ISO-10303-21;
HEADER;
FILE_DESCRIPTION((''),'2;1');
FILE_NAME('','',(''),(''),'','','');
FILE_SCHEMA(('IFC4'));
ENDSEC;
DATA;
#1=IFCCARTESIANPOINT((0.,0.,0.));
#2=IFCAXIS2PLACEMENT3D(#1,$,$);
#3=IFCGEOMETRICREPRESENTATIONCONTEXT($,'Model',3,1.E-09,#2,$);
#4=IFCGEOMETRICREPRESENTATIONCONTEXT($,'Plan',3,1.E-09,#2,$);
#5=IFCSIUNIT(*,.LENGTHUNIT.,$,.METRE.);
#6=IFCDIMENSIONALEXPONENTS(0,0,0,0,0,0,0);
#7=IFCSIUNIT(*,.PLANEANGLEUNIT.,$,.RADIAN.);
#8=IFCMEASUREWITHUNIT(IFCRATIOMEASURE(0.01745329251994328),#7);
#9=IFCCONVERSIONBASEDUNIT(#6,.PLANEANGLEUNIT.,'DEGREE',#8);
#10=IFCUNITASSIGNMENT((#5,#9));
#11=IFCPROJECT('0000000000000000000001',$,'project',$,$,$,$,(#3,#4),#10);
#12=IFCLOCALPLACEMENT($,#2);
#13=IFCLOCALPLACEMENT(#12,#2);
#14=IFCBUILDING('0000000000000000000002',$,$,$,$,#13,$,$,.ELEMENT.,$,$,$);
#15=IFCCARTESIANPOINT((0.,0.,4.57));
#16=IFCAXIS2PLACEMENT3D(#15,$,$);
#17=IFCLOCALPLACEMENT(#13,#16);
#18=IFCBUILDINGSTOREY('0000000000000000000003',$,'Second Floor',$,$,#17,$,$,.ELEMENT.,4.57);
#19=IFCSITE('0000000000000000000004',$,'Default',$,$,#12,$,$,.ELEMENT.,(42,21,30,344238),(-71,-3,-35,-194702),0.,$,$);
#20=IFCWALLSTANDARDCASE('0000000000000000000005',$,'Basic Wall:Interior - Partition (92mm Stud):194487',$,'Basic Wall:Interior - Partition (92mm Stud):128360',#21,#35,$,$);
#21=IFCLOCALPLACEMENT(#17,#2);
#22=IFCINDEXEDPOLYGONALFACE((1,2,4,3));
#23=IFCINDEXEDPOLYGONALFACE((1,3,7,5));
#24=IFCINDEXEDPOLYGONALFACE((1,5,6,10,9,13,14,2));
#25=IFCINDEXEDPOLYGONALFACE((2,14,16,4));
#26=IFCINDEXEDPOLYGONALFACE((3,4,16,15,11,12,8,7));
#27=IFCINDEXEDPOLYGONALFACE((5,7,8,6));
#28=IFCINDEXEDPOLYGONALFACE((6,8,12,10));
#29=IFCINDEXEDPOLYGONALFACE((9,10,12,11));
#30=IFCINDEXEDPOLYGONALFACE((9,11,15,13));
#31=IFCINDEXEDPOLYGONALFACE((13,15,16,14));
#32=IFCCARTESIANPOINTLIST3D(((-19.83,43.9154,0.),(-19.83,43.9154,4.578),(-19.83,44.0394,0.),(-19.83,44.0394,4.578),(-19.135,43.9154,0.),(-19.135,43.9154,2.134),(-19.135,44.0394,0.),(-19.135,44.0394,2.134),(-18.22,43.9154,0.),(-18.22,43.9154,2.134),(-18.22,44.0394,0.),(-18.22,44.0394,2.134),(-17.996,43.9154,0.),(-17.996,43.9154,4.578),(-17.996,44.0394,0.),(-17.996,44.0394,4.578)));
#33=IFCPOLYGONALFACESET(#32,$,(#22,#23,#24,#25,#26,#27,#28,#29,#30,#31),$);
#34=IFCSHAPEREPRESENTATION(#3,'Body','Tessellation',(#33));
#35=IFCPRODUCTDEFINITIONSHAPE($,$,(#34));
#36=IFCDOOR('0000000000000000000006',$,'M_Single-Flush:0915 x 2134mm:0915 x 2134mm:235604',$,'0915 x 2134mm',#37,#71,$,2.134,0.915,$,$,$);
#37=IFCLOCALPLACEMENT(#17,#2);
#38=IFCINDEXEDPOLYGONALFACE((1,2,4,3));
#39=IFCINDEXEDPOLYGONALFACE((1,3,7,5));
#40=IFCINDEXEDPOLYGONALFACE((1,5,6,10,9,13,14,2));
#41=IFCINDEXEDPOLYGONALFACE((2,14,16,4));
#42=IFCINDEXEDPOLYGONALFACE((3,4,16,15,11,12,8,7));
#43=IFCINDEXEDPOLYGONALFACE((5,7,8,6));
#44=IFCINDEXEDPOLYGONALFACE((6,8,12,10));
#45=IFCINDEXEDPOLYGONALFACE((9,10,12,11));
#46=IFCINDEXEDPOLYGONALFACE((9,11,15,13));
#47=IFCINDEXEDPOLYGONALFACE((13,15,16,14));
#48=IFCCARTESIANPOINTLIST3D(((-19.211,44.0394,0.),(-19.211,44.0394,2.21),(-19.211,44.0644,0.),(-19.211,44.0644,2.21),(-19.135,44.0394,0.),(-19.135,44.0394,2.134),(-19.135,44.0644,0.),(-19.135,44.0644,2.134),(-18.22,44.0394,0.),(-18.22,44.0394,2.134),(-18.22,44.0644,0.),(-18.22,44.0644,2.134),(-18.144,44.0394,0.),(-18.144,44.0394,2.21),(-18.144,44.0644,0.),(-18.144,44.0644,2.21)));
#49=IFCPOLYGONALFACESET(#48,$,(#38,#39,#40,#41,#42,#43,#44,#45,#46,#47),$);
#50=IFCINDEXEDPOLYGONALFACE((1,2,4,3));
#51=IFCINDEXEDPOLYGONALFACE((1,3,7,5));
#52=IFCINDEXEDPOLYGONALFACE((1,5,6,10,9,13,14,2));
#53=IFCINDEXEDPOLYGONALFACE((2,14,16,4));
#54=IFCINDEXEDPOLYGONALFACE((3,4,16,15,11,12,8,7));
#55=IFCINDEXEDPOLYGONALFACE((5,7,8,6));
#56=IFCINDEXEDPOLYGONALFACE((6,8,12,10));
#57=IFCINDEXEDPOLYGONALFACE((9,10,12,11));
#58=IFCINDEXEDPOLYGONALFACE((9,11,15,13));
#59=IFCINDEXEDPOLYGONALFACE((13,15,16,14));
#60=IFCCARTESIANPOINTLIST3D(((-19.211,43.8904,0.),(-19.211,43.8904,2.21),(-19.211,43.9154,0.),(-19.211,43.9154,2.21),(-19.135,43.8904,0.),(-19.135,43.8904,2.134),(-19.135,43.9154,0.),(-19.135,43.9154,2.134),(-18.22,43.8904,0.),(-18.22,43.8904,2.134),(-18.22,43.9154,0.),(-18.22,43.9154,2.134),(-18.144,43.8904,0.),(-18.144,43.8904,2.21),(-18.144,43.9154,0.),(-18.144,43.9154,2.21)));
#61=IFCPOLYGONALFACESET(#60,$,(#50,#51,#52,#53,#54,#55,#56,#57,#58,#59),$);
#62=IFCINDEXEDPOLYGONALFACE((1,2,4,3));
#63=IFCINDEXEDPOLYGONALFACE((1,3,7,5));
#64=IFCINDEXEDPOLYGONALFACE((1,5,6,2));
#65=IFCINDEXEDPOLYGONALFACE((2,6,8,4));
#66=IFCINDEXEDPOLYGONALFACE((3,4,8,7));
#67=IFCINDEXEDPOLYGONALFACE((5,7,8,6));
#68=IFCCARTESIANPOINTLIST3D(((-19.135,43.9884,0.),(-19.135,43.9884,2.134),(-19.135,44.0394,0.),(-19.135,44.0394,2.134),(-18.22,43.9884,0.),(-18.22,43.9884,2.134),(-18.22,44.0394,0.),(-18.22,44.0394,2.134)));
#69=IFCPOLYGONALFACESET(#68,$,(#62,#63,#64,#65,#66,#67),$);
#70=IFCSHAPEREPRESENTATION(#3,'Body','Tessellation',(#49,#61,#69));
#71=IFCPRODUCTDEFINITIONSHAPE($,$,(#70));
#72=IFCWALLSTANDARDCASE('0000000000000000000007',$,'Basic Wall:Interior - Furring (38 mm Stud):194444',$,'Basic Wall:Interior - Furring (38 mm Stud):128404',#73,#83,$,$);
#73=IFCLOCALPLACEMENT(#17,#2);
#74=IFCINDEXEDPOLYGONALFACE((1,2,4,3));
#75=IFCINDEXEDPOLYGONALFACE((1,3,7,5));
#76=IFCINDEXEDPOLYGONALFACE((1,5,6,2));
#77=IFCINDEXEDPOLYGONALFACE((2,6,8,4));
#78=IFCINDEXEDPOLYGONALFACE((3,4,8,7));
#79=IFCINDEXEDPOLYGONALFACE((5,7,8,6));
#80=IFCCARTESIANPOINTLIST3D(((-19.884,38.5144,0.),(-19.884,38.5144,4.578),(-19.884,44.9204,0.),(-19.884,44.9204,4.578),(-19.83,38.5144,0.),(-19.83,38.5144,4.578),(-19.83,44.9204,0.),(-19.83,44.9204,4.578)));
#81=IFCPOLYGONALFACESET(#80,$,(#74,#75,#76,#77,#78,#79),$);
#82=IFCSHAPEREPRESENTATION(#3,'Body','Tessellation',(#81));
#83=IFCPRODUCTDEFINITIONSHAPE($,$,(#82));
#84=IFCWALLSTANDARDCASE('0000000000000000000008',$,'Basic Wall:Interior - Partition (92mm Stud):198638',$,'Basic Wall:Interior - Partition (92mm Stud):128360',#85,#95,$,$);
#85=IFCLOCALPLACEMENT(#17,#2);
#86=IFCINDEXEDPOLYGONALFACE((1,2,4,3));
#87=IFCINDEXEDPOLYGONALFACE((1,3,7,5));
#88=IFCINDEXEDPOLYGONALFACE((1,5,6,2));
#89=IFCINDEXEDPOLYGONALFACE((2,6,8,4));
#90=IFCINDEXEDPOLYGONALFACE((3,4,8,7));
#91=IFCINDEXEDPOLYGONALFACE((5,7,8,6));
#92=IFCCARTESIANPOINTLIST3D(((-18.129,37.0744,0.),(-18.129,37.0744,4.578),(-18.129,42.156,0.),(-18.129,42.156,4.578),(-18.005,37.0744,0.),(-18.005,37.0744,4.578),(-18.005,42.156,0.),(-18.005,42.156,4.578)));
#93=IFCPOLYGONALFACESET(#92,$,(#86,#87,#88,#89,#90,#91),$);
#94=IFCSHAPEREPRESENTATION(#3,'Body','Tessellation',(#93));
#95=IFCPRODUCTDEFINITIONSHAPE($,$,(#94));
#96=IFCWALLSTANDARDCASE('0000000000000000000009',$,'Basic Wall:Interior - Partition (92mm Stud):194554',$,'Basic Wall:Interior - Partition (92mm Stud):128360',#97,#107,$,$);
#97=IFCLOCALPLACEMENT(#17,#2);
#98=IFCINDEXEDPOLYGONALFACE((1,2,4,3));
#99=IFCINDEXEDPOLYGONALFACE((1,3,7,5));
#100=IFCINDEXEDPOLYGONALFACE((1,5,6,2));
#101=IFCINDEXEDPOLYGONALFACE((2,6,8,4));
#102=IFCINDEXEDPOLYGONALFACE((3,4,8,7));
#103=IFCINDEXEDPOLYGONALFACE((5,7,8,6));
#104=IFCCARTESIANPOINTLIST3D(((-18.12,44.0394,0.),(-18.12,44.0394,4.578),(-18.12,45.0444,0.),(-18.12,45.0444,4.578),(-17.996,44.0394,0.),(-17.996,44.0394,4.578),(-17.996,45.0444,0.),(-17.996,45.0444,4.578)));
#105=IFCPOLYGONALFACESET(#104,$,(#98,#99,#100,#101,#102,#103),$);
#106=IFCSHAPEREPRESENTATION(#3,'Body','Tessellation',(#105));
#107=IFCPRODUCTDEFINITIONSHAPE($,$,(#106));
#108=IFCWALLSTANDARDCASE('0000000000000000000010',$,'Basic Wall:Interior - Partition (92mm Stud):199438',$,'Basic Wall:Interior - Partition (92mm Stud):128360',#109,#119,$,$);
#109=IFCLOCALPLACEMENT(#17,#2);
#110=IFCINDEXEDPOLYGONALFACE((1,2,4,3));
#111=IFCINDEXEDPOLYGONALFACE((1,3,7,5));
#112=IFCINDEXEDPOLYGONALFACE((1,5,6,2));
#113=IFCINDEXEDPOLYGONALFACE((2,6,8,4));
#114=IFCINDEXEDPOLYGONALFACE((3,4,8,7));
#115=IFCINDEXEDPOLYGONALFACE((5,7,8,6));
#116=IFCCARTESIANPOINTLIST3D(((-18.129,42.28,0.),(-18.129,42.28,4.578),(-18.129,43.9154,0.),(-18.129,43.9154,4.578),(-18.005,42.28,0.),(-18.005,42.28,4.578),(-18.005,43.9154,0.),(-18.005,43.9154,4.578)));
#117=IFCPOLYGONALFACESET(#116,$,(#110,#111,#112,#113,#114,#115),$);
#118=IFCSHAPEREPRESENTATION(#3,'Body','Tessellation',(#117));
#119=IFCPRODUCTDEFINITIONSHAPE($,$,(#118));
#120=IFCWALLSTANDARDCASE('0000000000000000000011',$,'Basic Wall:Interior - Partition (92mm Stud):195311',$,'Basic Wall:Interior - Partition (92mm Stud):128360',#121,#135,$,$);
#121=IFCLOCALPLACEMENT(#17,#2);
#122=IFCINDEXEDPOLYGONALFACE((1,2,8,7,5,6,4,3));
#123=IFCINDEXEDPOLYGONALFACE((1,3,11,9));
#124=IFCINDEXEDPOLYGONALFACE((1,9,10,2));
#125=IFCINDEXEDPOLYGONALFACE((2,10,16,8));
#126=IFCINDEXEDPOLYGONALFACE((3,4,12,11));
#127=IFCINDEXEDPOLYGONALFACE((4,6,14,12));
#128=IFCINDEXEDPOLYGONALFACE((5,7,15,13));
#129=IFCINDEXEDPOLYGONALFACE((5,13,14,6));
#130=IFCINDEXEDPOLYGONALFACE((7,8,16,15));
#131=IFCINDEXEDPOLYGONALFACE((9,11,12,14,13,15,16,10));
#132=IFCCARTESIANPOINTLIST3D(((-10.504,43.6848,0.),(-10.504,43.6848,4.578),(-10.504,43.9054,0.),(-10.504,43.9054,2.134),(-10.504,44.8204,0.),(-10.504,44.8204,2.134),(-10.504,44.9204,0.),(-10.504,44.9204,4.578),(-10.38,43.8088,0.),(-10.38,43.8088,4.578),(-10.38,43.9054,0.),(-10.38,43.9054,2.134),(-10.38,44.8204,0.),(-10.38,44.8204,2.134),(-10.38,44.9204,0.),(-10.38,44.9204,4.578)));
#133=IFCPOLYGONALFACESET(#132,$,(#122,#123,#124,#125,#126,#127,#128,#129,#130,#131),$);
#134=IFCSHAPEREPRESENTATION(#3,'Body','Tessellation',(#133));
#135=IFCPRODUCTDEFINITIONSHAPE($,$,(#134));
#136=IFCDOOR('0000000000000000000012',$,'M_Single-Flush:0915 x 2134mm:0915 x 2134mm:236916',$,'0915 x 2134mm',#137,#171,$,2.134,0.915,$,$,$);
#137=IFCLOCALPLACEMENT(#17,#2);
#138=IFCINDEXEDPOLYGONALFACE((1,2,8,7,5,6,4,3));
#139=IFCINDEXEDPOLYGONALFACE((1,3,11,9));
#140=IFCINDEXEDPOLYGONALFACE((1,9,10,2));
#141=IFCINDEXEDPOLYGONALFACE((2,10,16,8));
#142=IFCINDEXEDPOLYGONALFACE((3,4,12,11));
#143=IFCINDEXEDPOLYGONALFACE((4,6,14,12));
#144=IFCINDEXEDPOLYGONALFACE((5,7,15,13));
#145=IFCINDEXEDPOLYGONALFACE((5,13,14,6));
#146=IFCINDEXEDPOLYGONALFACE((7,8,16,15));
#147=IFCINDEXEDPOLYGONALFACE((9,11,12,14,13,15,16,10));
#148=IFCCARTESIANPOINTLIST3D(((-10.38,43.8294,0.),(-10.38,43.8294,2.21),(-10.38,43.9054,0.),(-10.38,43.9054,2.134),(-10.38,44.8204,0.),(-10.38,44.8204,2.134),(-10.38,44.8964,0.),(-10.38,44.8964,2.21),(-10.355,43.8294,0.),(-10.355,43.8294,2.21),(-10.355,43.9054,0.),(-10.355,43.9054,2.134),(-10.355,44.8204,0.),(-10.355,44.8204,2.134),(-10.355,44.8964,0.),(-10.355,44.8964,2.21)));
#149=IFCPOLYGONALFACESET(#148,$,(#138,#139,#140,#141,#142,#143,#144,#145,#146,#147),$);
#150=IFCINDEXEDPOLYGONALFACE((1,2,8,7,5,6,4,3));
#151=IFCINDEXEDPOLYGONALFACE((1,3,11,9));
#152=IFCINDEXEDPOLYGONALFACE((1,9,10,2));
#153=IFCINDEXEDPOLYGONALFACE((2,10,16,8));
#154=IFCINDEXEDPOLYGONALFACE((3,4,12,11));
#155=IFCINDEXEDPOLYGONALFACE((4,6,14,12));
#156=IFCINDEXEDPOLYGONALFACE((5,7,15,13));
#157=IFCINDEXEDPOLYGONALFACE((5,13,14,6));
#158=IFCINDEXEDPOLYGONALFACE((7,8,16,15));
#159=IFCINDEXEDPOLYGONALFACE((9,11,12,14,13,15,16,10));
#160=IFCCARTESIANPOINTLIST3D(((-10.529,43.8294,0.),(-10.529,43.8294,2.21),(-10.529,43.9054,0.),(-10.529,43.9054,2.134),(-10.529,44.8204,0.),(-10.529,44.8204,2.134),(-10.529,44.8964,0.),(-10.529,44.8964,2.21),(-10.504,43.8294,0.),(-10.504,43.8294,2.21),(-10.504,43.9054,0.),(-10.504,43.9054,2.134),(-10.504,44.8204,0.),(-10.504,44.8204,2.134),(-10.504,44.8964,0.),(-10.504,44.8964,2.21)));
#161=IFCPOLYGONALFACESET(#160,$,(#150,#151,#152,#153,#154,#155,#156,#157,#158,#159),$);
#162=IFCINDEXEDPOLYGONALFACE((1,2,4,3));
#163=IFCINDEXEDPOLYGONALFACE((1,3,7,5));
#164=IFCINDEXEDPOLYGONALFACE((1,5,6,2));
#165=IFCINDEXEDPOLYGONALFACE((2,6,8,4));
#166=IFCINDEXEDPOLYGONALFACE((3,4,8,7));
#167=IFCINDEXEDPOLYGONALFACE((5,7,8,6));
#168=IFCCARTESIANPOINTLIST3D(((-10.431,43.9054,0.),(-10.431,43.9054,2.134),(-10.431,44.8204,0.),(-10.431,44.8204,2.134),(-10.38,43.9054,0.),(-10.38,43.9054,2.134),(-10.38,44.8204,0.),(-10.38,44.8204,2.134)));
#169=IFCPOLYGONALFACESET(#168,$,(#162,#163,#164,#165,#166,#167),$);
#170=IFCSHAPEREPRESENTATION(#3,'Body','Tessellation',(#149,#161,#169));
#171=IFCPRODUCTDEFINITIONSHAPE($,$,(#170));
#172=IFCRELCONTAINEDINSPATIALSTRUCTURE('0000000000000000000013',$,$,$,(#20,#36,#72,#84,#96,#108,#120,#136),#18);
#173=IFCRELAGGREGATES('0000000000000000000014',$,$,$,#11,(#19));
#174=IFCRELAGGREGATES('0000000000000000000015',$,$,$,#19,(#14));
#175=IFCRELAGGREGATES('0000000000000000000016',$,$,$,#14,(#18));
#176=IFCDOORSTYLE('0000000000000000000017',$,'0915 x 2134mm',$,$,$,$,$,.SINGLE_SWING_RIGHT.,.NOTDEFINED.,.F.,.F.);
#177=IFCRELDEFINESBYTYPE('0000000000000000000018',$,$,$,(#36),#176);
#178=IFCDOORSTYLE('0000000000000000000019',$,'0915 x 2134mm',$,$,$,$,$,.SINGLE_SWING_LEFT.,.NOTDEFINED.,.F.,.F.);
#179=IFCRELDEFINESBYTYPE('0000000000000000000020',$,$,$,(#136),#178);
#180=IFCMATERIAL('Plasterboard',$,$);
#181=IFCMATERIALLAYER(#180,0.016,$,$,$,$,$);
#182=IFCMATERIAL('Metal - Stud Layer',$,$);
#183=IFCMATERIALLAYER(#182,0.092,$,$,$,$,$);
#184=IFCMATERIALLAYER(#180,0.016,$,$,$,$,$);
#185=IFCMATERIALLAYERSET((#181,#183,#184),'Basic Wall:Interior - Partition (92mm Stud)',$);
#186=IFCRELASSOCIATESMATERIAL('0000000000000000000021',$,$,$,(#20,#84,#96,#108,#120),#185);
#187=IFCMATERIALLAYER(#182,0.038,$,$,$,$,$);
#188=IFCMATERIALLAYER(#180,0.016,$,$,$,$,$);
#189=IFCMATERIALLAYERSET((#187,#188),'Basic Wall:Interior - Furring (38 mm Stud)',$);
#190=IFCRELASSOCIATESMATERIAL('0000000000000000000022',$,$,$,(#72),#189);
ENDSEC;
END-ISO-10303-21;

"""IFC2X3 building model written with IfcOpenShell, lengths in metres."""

from ifc_helpers import new_model, entity, si_unit, converted_unit, frame, frame_2d, origin, origin_2d_with_axis, place, context, project, spatial, polyline, rectangle, outline, extrude, source, transform, mapped, material, layer, layer_set, layer_usage, type_object, type_shapes, element, fill, save


model = new_model("IFC2X3")

# Units and contexts
model_context = context("Model", 3, precision=1e-09, world=origin())
plan_context = context("Plan", 3, precision=1e-09, world=origin())
ifc_project = project(units=[si_unit("LENGTHUNIT", "METRE"), converted_unit("PLANEANGLEUNIT", "DEGREE", entity("IfcRatioMeasure", 0.01745329251994328), si_unit("PLANEANGLEUNIT", "RADIAN"), dimensions=[0, 0, 0, 0, 0, 0, 0])], contexts=[model_context, plan_context])

# Site, building, storey
site_placement = place(None, origin())
site = spatial("IfcSite", under=ifc_project, at=site_placement, Name="Default", CompositionType="ELEMENT", RefLatitude=(42, 21, 30, 344238), RefLongitude=(-71, -3, -35, -194702), RefElevation=0.0)
building_placement = place(site_placement, origin())
building = spatial("IfcBuilding", under=site, at=building_placement, CompositionType="ELEMENT")
storey_placement = place(building_placement, frame((0.0, 0.0, 4.57)))
storey = spatial("IfcBuildingStorey", under=building, at=storey_placement, Name="Second Floor", CompositionType="ELEMENT", Elevation=4.57)

# Shared definitions
ifc_material_1 = material(Name="Plasterboard")
ifc_layer_1 = layer(ifc_material_1, 0.016)
ifc_material_2 = material(Name="Metal - Stud Layer")
ifc_layer_2 = layer(ifc_material_2, 0.092)
ifc_layer_3 = layer(ifc_material_1, 0.016)
ifc_layer_set_1 = layer_set([ifc_layer_1, ifc_layer_2, ifc_layer_3], Name="Basic Wall:Interior - Partition (92mm Stud)")
ifc_layer_usage_1 = layer_usage(ifc_layer_set_1, "AXIS2", "NEGATIVE", 0.062)
door_style_1 = type_object("IfcDoorStyle", Name="0915 x 2134mm", ConstructionType="NOTDEFINED", OperationType="SINGLE_SWING_LEFT", ParameterTakesPrecedence=False, Sizeable=False)
shared_shape_1 = source(origin(), model_context, "Body", "SweptSolid", [
    extrude(outline(polyline([(-0.5335, -1.124), (0.5335, -1.124), (0.5335, 1.086), (0.4575, 1.086), (0.4575, -1.048), (-0.4575, -1.048), (-0.4575, 1.086), (-0.5335, 1.086), (-0.5335, -1.124)])), frame((0.4575, 0.149, 1.086), z_axis=(0.0, -1.0, 0.0), x_axis=(-1.0, 0.0, 0.0)), (0.0, 0.0, 1.0), 0.025),
    extrude(outline(polyline([(-1.124, -0.5335), (1.086, -0.5335), (1.086, -0.4575), (-1.048, -0.4575), (-1.048, 0.4575), (1.086, 0.4575), (1.086, 0.5335), (-1.124, 0.5335), (-1.124, -0.5335)])), frame((0.4575, 0.0, 1.086), z_axis=(0.0, -1.0, 0.0), x_axis=(0.0, 0.0, -1.0)), (0.0, 0.0, 1.0), 0.025),
    extrude(rectangle(XDim=0.915, YDim=0.051, at=origin_2d_with_axis()), frame((0.4575, 0.0985, 0.0)), (0.0, 0.0, 1.0), 2.134),
])
type_shapes(door_style_1, [shared_shape_1])

# Shared definitions
ifc_layer_4 = layer(ifc_material_2, 0.038)
ifc_layer_5 = layer(ifc_material_1, 0.016)
ifc_layer_set_2 = layer_set([ifc_layer_4, ifc_layer_5], Name="Basic Wall:Interior - Furring (38 mm Stud)")
ifc_layer_usage_2 = layer_usage(ifc_layer_set_2, "AXIS2", "POSITIVE", -0.027)

# Wall, opening, door
wall_1_placement = place(storey_placement, frame((-19.83, 43.9774, 0.0)))
wall_1 = element("IfcWallStandardCase", 1, at=wall_1_placement, inside=storey, material=ifc_layer_usage_1, Name="Basic Wall:Interior - Partition (92mm Stud):194487", ObjectType="Basic Wall:Interior - Partition (92mm Stud):128360", context=model_context, shape_type="SweptSolid", body=[
    extrude(rectangle(XDim=1.834, YDim=0.124, at=frame_2d((0.917, 0.0), x_axis=(-1.0, 0.0))), origin(), (0.0, 0.0, 1.0), 4.578),
])
opening_1_placement = place(wall_1_placement, frame((0.695, -0.062, 0.0)))
opening_1 = element("IfcOpeningElement", 2, at=opening_1_placement, cuts=wall_1, ObjectType="Opening", context=model_context, shape_type="SweptSolid", body=[
    extrude(rectangle(XDim=0.915, YDim=2.134, at=frame_2d((1.067, 0.4575), x_axis=(0.0, 1.0))), frame((0.0, 0.0, 0.0), z_axis=(0.0, 1.0, 0.0), x_axis=(0.0, 0.0, 1.0)), (0.0, 0.0, 1.0), 0.124),
])
door_style_2 = type_object("IfcDoorStyle", Name="0915 x 2134mm", ConstructionType="NOTDEFINED", OperationType="SINGLE_SWING_RIGHT", ParameterTakesPrecedence=False, Sizeable=False)
shared_shape_2 = source(origin(), model_context, "Body", "SweptSolid", [
    extrude(outline(polyline([(-0.5335, -1.124), (0.5335, -1.124), (0.5335, 1.086), (0.4575, 1.086), (0.4575, -1.048), (-0.4575, -1.048), (-0.4575, 1.086), (-0.5335, 1.086), (-0.5335, -1.124)])), frame((0.4575, 0.124, 1.086), z_axis=(0.0, 1.0, 0.0), x_axis=(1.0, 0.0, 0.0)), (0.0, 0.0, 1.0), 0.025),
    extrude(outline(polyline([(-1.124, -0.5335), (1.086, -0.5335), (1.086, -0.4575), (-1.048, -0.4575), (-1.048, 0.4575), (1.086, 0.4575), (1.086, 0.5335), (-1.124, 0.5335), (-1.124, -0.5335)])), frame((0.4575, -0.025, 1.086), z_axis=(0.0, 1.0, 0.0), x_axis=(0.0, 0.0, -1.0)), (0.0, 0.0, 1.0), 0.025),
    extrude(rectangle(XDim=0.051, YDim=0.915, at=origin_2d_with_axis()), frame((0.4575, 0.0985, 0.0), z_axis=(0.0, 0.0, 1.0), x_axis=(0.0, 1.0, 0.0)), (0.0, 0.0, 1.0), 2.134),
])
type_shapes(door_style_2, [shared_shape_2])
door_1_placement = place(opening_1_placement, origin())
door_1 = element("IfcDoor", 3, at=door_1_placement, inside=storey, type_object=door_style_2, Name="M_Single-Flush:0915 x 2134mm:0915 x 2134mm:235604", ObjectType="0915 x 2134mm", OverallHeight=2.134, OverallWidth=0.915, context=model_context, shape_type="MappedRepresentation", body=[
    mapped(shared_shape_2, transform((0.0, 0.0, 0.0), scale=1.0)),
])
fill(opening_1, door_1)

# Walls
wall_2_placement = place(storey_placement, frame((-19.857, 44.9204, 0.0), z_axis=(0.0, 0.0, 1.0), x_axis=(0.0, -1.0, 0.0)))
element("IfcWallStandardCase", 4, at=wall_2_placement, inside=storey, material=ifc_layer_usage_2, Name="Basic Wall:Interior - Furring (38 mm Stud):194444", ObjectType="Basic Wall:Interior - Furring (38 mm Stud):128404", context=model_context, shape_type="SweptSolid", body=[
    extrude(rectangle(XDim=6.4061, YDim=0.054, at=frame_2d((3.203, 0.0), x_axis=(-1.0, 0.0))), origin(), (0.0, 0.0, 1.0), 4.578),
])
wall_3_placement = place(storey_placement, frame((-18.067, 42.156, 0.0), z_axis=(0.0, 0.0, 1.0), x_axis=(0.0, -1.0, 0.0)))
element("IfcWallStandardCase", 5, at=wall_3_placement, inside=storey, material=ifc_layer_usage_1, Name="Basic Wall:Interior - Partition (92mm Stud):198638", ObjectType="Basic Wall:Interior - Partition (92mm Stud):128360", context=model_context, shape_type="SweptSolid", body=[
    extrude(rectangle(XDim=5.0816, YDim=0.124, at=frame_2d((2.5408, 0.0), x_axis=(-1.0, 0.0))), origin(), (0.0, 0.0, 1.0), 4.578),
])
wall_4_placement = place(storey_placement, frame((-18.058, 44.0394, 0.0), z_axis=(0.0, 0.0, 1.0), x_axis=(0.0, 1.0, 0.0)))
element("IfcWallStandardCase", 6, at=wall_4_placement, inside=storey, material=ifc_layer_usage_1, Name="Basic Wall:Interior - Partition (92mm Stud):194554", ObjectType="Basic Wall:Interior - Partition (92mm Stud):128360", context=model_context, shape_type="SweptSolid", body=[
    extrude(rectangle(XDim=1.005, YDim=0.124, at=frame_2d((0.5025, 0.0), x_axis=(-1.0, 0.0))), origin(), (0.0, 0.0, 1.0), 4.578),
])
wall_5_placement = place(storey_placement, frame((-18.067, 42.28, 0.0), z_axis=(0.0, 0.0, 1.0), x_axis=(0.0, 1.0, 0.0)))
element("IfcWallStandardCase", 7, at=wall_5_placement, inside=storey, material=ifc_layer_usage_1, Name="Basic Wall:Interior - Partition (92mm Stud):199438", ObjectType="Basic Wall:Interior - Partition (92mm Stud):128360", context=model_context, shape_type="SweptSolid", body=[
    extrude(rectangle(XDim=1.6354, YDim=0.124, at=frame_2d((0.8177, 0.0), x_axis=(-1.0, 0.0))), origin(), (0.0, 0.0, 1.0), 4.578),
])

# Wall, opening, door
wall_6_placement = place(storey_placement, frame((-10.442, 44.9204, 0.0), z_axis=(0.0, 0.0, 1.0), x_axis=(0.0, -1.0, 0.0)))
wall_6 = element("IfcWallStandardCase", 8, at=wall_6_placement, inside=storey, material=ifc_layer_usage_1, Name="Basic Wall:Interior - Partition (92mm Stud):195311", ObjectType="Basic Wall:Interior - Partition (92mm Stud):128360", context=model_context, shape_type="SweptSolid", body=[
    extrude(outline(polyline([(0.0, -0.062), (1.0602, -0.062), (1.2356, -0.062), (1.1116, 0.062), (0.0, 0.062), (0.0, -0.062)])), origin(), (0.0, 0.0, 1.0), 4.578),
])
opening_2_placement = place(wall_6_placement, frame((0.1, -0.062, 0.0)))
opening_2 = element("IfcOpeningElement", 9, at=opening_2_placement, cuts=wall_6, ObjectType="Opening", context=model_context, shape_type="SweptSolid", body=[
    extrude(rectangle(XDim=0.915, YDim=2.134, at=frame_2d((1.067, 0.4575), x_axis=(0.0, -1.0))), frame((0.0, 0.0, 0.0), z_axis=(0.0, 1.0, 0.0), x_axis=(0.0, 0.0, 1.0)), (0.0, 0.0, 1.0), 0.124),
])
door_2_placement = place(opening_2_placement, origin())
door_2 = element("IfcDoor", 10, at=door_2_placement, inside=storey, type_object=door_style_1, Name="M_Single-Flush:0915 x 2134mm:0915 x 2134mm:236916", ObjectType="0915 x 2134mm", OverallHeight=2.134, OverallWidth=0.915, context=model_context, shape_type="MappedRepresentation", body=[
    mapped(shared_shape_1, transform((0.0, 0.0, 0.0), scale=1.0)),
])
fill(opening_2, door_2)

save(model, "model.ifc")
